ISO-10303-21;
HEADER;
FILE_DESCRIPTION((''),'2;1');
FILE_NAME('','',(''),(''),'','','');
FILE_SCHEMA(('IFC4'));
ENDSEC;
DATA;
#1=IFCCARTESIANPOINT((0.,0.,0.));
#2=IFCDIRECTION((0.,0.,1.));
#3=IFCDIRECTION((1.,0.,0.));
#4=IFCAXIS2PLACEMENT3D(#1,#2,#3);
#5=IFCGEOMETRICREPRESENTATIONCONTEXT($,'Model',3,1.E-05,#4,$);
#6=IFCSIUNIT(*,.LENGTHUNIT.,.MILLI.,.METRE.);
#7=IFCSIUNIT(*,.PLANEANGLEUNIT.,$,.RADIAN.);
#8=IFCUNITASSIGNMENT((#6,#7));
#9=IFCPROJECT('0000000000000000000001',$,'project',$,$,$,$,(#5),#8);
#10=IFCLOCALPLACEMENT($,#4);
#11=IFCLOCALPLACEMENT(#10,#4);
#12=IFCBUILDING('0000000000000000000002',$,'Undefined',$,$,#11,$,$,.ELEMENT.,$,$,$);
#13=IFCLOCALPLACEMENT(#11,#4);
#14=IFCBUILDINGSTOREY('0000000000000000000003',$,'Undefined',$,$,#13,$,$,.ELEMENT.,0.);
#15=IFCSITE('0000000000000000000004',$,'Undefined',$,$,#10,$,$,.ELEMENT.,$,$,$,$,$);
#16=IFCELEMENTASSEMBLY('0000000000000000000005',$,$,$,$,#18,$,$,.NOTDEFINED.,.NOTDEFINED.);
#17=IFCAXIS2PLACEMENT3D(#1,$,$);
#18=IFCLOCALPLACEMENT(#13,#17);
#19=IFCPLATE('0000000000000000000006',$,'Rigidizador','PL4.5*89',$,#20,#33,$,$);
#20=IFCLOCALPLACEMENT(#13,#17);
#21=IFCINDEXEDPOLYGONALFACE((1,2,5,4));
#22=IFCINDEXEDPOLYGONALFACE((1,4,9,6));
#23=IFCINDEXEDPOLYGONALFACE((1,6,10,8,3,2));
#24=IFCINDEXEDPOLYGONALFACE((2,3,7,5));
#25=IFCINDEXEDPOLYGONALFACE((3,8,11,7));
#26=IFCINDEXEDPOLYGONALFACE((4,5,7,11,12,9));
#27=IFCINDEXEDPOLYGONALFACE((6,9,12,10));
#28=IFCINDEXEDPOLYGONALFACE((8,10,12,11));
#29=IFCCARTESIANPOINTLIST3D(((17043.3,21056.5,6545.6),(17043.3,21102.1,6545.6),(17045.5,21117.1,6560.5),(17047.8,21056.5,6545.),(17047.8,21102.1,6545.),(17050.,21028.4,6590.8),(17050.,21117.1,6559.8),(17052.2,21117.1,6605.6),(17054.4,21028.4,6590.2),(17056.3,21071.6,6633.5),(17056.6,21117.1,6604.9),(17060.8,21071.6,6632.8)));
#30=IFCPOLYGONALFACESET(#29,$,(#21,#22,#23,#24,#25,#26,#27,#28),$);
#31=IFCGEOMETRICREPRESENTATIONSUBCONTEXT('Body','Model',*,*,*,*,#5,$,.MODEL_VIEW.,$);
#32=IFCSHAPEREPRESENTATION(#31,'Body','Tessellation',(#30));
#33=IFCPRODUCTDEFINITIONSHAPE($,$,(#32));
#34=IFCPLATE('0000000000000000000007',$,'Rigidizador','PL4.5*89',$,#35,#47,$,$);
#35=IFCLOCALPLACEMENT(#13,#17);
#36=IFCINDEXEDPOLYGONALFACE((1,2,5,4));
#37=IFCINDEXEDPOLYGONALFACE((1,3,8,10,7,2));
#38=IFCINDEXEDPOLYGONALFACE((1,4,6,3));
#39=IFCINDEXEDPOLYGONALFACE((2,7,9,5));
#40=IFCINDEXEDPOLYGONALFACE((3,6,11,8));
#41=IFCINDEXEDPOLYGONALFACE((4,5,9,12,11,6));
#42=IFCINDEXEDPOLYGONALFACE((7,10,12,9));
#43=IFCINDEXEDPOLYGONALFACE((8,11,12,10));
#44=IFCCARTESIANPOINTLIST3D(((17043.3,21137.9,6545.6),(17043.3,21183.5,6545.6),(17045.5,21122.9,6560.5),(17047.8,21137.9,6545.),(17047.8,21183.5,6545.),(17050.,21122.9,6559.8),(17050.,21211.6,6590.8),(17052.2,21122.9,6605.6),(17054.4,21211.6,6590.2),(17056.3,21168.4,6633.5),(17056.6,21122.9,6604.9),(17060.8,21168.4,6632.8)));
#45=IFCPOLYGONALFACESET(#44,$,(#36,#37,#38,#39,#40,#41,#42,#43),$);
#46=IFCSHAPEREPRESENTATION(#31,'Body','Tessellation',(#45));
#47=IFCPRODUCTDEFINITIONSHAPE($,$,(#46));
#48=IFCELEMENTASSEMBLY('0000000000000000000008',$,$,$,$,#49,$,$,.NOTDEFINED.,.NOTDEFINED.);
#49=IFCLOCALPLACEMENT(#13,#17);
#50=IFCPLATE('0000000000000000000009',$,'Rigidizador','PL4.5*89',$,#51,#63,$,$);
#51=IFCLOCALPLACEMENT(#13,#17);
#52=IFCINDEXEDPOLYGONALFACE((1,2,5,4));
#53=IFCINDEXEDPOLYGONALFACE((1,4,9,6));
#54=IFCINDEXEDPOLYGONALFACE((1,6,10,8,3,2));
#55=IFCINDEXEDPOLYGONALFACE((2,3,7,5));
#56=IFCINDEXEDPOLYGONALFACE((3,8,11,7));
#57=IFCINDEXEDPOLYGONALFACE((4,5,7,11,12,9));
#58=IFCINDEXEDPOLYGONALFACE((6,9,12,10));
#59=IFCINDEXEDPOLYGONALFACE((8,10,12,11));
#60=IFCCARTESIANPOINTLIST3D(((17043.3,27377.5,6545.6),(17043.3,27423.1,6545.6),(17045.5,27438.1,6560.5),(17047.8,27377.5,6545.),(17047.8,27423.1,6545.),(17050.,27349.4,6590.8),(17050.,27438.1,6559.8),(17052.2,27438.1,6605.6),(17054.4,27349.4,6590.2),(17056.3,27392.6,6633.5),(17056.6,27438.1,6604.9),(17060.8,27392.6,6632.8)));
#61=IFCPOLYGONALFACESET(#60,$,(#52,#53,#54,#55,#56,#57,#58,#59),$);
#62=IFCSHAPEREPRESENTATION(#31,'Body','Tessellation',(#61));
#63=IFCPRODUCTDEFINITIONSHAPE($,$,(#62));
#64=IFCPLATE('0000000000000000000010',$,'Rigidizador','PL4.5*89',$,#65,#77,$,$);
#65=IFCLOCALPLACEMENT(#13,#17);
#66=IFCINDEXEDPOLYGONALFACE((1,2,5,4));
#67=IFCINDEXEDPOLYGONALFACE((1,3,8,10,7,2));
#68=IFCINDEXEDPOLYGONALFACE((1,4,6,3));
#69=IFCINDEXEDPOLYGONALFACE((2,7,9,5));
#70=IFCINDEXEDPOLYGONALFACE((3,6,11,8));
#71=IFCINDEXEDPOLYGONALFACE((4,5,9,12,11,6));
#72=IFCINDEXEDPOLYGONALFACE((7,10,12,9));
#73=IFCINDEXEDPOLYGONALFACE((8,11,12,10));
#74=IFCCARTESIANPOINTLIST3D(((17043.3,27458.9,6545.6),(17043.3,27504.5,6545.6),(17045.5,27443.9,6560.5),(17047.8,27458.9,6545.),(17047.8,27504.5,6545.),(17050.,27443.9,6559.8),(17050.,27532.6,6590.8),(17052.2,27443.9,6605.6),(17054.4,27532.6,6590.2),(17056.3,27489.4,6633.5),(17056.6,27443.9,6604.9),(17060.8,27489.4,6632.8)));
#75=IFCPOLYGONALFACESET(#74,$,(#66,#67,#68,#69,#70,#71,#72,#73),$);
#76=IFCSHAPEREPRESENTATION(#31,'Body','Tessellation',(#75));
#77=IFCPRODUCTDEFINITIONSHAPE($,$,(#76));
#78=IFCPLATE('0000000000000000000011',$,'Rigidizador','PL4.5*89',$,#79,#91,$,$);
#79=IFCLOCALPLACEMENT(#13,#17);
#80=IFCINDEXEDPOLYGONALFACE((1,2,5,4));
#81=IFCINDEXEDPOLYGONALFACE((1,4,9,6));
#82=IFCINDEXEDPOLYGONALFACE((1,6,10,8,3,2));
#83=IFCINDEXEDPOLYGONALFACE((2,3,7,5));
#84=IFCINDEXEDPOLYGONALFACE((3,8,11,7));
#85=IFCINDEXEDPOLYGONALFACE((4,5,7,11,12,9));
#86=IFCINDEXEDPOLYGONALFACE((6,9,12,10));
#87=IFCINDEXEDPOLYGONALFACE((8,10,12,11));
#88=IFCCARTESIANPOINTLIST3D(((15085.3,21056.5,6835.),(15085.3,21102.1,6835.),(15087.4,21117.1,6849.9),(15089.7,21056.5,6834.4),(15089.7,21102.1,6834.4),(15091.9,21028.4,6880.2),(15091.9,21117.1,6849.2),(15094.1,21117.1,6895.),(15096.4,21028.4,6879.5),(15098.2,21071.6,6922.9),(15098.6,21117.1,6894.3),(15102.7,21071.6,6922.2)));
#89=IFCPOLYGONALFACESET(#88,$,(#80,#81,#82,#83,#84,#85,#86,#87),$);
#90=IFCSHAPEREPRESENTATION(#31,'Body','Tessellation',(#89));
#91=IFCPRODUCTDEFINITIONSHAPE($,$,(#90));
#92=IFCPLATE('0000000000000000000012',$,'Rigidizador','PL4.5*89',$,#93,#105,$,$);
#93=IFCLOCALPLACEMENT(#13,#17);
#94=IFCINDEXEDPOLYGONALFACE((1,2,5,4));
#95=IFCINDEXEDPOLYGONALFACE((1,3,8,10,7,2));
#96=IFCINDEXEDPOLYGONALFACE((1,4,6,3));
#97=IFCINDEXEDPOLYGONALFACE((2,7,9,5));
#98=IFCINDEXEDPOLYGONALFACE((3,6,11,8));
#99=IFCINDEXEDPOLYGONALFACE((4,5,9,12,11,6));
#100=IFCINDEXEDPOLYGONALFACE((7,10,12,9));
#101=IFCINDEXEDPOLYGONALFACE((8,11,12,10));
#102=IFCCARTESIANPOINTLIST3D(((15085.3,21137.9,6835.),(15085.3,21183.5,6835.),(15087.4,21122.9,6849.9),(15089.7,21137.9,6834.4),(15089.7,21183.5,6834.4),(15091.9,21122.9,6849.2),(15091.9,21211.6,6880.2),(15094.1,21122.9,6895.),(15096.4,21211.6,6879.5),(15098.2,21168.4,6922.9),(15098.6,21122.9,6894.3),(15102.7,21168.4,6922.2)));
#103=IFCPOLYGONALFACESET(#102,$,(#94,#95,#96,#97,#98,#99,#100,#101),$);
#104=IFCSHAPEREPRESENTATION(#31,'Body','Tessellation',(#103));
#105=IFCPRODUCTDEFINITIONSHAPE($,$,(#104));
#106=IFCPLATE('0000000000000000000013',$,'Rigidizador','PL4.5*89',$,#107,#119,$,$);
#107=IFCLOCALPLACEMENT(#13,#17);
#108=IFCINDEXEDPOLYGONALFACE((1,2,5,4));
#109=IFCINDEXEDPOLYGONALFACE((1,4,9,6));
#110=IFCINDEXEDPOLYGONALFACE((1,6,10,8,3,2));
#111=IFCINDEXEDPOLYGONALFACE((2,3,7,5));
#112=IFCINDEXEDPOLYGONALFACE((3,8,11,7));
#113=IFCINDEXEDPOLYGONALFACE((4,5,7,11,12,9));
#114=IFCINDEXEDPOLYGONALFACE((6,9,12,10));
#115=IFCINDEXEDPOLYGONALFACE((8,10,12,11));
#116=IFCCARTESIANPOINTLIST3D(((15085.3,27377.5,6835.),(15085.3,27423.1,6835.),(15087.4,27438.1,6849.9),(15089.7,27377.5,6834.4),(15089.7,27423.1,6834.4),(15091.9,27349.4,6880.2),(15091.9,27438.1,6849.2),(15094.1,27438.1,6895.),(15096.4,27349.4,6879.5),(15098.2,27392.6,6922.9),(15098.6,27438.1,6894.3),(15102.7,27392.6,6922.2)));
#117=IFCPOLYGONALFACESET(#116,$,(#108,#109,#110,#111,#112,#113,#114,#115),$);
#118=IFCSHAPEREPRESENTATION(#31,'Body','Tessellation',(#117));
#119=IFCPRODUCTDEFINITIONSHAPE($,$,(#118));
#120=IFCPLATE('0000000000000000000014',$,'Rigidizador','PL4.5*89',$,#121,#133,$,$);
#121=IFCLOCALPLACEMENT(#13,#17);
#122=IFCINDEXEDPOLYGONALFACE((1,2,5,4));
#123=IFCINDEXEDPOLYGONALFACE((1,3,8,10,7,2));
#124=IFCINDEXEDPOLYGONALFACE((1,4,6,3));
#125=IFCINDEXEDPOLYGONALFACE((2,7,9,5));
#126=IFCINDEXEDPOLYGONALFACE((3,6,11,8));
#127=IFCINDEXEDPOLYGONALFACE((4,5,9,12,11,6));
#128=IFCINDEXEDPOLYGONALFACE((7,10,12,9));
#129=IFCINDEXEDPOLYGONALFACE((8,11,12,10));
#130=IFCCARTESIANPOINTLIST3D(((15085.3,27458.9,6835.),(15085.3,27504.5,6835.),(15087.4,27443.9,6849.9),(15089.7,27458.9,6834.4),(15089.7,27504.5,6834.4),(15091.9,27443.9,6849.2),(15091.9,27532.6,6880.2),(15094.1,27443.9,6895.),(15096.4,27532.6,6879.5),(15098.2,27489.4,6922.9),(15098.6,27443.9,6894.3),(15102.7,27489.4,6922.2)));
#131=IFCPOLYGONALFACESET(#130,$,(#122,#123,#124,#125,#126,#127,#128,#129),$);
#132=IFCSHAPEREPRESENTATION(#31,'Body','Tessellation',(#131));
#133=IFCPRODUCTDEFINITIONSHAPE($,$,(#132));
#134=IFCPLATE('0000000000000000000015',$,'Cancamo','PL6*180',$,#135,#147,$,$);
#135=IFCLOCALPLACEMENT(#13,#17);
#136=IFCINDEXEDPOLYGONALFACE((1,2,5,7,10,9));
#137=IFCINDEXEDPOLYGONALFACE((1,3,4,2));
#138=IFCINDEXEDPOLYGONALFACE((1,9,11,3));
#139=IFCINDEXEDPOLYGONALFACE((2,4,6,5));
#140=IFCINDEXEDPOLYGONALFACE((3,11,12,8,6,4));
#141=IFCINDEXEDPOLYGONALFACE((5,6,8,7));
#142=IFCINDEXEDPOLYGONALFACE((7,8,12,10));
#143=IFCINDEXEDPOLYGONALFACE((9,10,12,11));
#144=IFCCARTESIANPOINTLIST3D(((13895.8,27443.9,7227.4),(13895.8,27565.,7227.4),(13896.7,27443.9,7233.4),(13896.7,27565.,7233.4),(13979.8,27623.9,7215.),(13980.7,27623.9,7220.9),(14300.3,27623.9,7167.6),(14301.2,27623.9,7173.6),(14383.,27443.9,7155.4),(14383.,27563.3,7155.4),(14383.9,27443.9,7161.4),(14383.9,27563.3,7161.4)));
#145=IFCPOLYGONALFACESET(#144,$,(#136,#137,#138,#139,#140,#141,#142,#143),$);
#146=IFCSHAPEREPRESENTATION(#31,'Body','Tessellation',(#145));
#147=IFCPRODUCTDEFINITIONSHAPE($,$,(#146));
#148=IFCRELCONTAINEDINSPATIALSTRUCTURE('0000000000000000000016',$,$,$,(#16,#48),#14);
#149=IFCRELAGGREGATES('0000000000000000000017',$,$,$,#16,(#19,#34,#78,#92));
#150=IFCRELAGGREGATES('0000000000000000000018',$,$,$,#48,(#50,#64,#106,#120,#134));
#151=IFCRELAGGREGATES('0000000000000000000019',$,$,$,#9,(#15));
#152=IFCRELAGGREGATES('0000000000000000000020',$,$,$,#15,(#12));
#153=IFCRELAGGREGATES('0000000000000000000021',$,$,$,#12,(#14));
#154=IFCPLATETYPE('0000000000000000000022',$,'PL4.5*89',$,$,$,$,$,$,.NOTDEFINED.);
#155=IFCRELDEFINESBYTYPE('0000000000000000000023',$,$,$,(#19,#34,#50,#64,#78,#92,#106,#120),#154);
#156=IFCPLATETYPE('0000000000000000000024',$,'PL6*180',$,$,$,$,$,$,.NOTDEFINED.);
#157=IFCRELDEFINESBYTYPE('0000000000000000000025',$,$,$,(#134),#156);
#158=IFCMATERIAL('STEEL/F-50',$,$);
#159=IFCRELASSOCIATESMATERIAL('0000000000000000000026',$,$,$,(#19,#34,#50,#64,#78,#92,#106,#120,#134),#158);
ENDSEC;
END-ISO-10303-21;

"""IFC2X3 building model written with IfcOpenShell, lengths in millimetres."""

from ifc_helpers import new_model, si_unit, frame, origin_with_axes, place, context, subcontext, project, spatial, polyline, outline, extrude, material, type_object, element, aggregate, save


model = new_model("IFC2X3")

# Units and contexts
model_context = context("Model", 3, precision=1e-05, world=origin_with_axes())
body_context = subcontext(model_context, "Body", "Model", "MODEL_VIEW")
ifc_project = project(units=[si_unit("LENGTHUNIT", "METRE", prefix="MILLI"), si_unit("PLANEANGLEUNIT", "RADIAN")], contexts=[model_context])

# Site, building, storey
site_placement = place(None, origin_with_axes())
site = spatial("IfcSite", under=ifc_project, at=site_placement, Name="Undefined", CompositionType="ELEMENT")
building_placement = place(site_placement, origin_with_axes())
building = spatial("IfcBuilding", under=site, at=building_placement, Name="Undefined", CompositionType="ELEMENT")
storey_placement = place(building_placement, origin_with_axes())
storey = spatial("IfcBuildingStorey", under=building, at=storey_placement, Name="Undefined", CompositionType="ELEMENT", Elevation=0.0)

# Element assemblies, plates
assembly_1_placement = place(storey_placement, origin_with_axes())
assembly_1 = element("IfcElementAssembly", 1, at=assembly_1_placement, inside=storey, AssemblyPlace="NOTDEFINED", PredefinedType="NOTDEFINED")
ifc_material_1 = material(Name="STEEL/F-50")
plate_type_1 = type_object("IfcPlateType", Name="PL4.5*89", PredefinedType="NOTDEFINED")
plate_1_placement = place(assembly_1_placement, frame((17045.5, 21056.5, 6545.3), z_axis=(0.989255, 0.0, -0.146202), x_axis=(0.0, 1.0, 0.0)))
plate_1 = element("IfcPlate", 2, at=plate_1_placement, type_object=plate_type_1, material=ifc_material_1, Name="Rigidizador", Description="PL4.5*89", context=body_context, shape_type="SweptSolid", body=[
    extrude(outline(polyline([(0.0, 0.0), (45.6, 0.0), (60.6, 15.0), (60.6, 60.6), (15.1, 88.8), (-28.1, 45.7), (0.0, 0.0)])), frame((0.0, 0.0, -2.2), z_axis=(0.0, 0.0, 1.0), x_axis=(1.0, 0.0, 0.0)), (0.0, 0.0, 1.0), 4.5),
])
plate_2_placement = place(assembly_1_placement, frame((17045.5, 21183.5, 6545.3), z_axis=(-0.989255, 0.0, 0.146202), x_axis=(0.0, -1.0, 0.0)))
plate_2 = element("IfcPlate", 3, at=plate_2_placement, type_object=plate_type_1, material=ifc_material_1, Name="Rigidizador", Description="PL4.5*89", context=body_context, shape_type="SweptSolid", body=[
    extrude(outline(polyline([(0.0, 0.0), (45.6, 0.0), (60.6, 15.0), (60.6, 60.6), (15.1, 88.8), (-28.1, 45.7), (0.0, 0.0)])), frame((0.0, 0.0, -2.2), z_axis=(0.0, 0.0, 1.0), x_axis=(1.0, 0.0, 0.0)), (0.0, 0.0, 1.0), 4.5),
])
assembly_2_placement = place(storey_placement, origin_with_axes())
assembly_2 = element("IfcElementAssembly", 4, at=assembly_2_placement, inside=storey, AssemblyPlace="NOTDEFINED", PredefinedType="NOTDEFINED")
plate_3_placement = place(assembly_2_placement, frame((17045.5, 27377.5, 6545.3), z_axis=(0.989255, 0.0, -0.146202), x_axis=(0.0, 1.0, 0.0)))
plate_3 = element("IfcPlate", 5, at=plate_3_placement, type_object=plate_type_1, material=ifc_material_1, Name="Rigidizador", Description="PL4.5*89", context=body_context, shape_type="SweptSolid", body=[
    extrude(outline(polyline([(0.0, 0.0), (45.6, 0.0), (60.6, 15.0), (60.6, 60.6), (15.1, 88.8), (-28.1, 45.7), (0.0, 0.0)])), frame((0.0, 0.0, -2.2), z_axis=(0.0, 0.0, 1.0), x_axis=(1.0, 0.0, 0.0)), (0.0, 0.0, 1.0), 4.5),
])
plate_4_placement = place(assembly_2_placement, frame((17045.5, 27504.5, 6545.3), z_axis=(-0.989255, 0.0, 0.146202), x_axis=(0.0, -1.0, 0.0)))
plate_4 = element("IfcPlate", 6, at=plate_4_placement, type_object=plate_type_1, material=ifc_material_1, Name="Rigidizador", Description="PL4.5*89", context=body_context, shape_type="SweptSolid", body=[
    extrude(outline(polyline([(0.0, 0.0), (45.6, 0.0), (60.6, 15.0), (60.6, 60.6), (15.1, 88.8), (-28.1, 45.7), (0.0, 0.0)])), frame((0.0, 0.0, -2.2), z_axis=(0.0, 0.0, 1.0), x_axis=(1.0, 0.0, 0.0)), (0.0, 0.0, 1.0), 4.5),
])

# Plates
plate_5_placement = place(assembly_1_placement, frame((15087.5, 21056.5, 6834.7), z_axis=(0.989255, 0.0, -0.146202), x_axis=(0.0, 1.0, 0.0)))
plate_5 = element("IfcPlate", 7, at=plate_5_placement, type_object=plate_type_1, material=ifc_material_1, Name="Rigidizador", Description="PL4.5*89", context=body_context, shape_type="SweptSolid", body=[
    extrude(outline(polyline([(0.0, 0.0), (45.6, 0.0), (60.6, 15.0), (60.6, 60.6), (15.1, 88.8), (-28.1, 45.7), (0.0, 0.0)])), frame((0.0, 0.0, -2.2), z_axis=(0.0, 0.0, 1.0), x_axis=(1.0, 0.0, 0.0)), (0.0, 0.0, 1.0), 4.5),
])
plate_6_placement = place(assembly_1_placement, frame((15087.5, 21183.5, 6834.7), z_axis=(-0.989255, 0.0, 0.146202), x_axis=(0.0, -1.0, 0.0)))
plate_6 = element("IfcPlate", 8, at=plate_6_placement, type_object=plate_type_1, material=ifc_material_1, Name="Rigidizador", Description="PL4.5*89", context=body_context, shape_type="SweptSolid", body=[
    extrude(outline(polyline([(0.0, 0.0), (45.6, 0.0), (60.6, 15.0), (60.6, 60.6), (15.1, 88.8), (-28.1, 45.7), (0.0, 0.0)])), frame((0.0, 0.0, -2.2), z_axis=(0.0, 0.0, 1.0), x_axis=(1.0, 0.0, 0.0)), (0.0, 0.0, 1.0), 4.5),
])
plate_7_placement = place(assembly_2_placement, frame((15087.5, 27377.5, 6834.7), z_axis=(0.989255, 0.0, -0.146202), x_axis=(0.0, 1.0, 0.0)))
plate_7 = element("IfcPlate", 9, at=plate_7_placement, type_object=plate_type_1, material=ifc_material_1, Name="Rigidizador", Description="PL4.5*89", context=body_context, shape_type="SweptSolid", body=[
    extrude(outline(polyline([(0.0, 0.0), (45.6, 0.0), (60.6, 15.0), (60.6, 60.6), (15.1, 88.8), (-28.1, 45.7), (0.0, 0.0)])), frame((0.0, 0.0, -2.2), z_axis=(0.0, 0.0, 1.0), x_axis=(1.0, 0.0, 0.0)), (0.0, 0.0, 1.0), 4.5),
])
plate_8_placement = place(assembly_2_placement, frame((15087.5, 27504.5, 6834.7), z_axis=(-0.989255, 0.0, 0.146202), x_axis=(0.0, -1.0, 0.0)))
plate_8 = element("IfcPlate", 10, at=plate_8_placement, type_object=plate_type_1, material=ifc_material_1, Name="Rigidizador", Description="PL4.5*89", context=body_context, shape_type="SweptSolid", body=[
    extrude(outline(polyline([(0.0, 0.0), (45.6, 0.0), (60.6, 15.0), (60.6, 60.6), (15.1, 88.8), (-28.1, 45.7), (0.0, 0.0)])), frame((0.0, 0.0, -2.2), z_axis=(0.0, 0.0, 1.0), x_axis=(1.0, 0.0, 0.0)), (0.0, 0.0, 1.0), 4.5),
])
plate_type_2 = type_object("IfcPlateType", Name="PL6*180", PredefinedType="NOTDEFINED")
plate_9_placement = place(assembly_2_placement, frame((14383.4, 27443.9, 7158.4), z_axis=(-0.146202, 0.0, -0.989255), x_axis=(-0.989255, 0.0, 0.146202)))
plate_9 = element("IfcPlate", 11, at=plate_9_placement, type_object=plate_type_2, material=ifc_material_1, Name="Cancamo", Description="PL6*180", context=body_context, shape_type="SweptSolid", body=[
    extrude(outline(polyline([(0.0, 0.0), (492.4, 0.0), (492.4, 121.1), (407.6, 180.0), (83.6, 180.0), (0.0, 119.4), (0.0, 0.0)])), frame((0.0, 0.0, -3.0), z_axis=(0.0, 0.0, 1.0), x_axis=(1.0, 0.0, 0.0)), (0.0, 0.0, 1.0), 6.0),
])

aggregate(assembly_1, [plate_1, plate_2, plate_5, plate_6])
aggregate(assembly_2, [plate_3, plate_4, plate_7, plate_8, plate_9])

save(model, "model.ifc")
